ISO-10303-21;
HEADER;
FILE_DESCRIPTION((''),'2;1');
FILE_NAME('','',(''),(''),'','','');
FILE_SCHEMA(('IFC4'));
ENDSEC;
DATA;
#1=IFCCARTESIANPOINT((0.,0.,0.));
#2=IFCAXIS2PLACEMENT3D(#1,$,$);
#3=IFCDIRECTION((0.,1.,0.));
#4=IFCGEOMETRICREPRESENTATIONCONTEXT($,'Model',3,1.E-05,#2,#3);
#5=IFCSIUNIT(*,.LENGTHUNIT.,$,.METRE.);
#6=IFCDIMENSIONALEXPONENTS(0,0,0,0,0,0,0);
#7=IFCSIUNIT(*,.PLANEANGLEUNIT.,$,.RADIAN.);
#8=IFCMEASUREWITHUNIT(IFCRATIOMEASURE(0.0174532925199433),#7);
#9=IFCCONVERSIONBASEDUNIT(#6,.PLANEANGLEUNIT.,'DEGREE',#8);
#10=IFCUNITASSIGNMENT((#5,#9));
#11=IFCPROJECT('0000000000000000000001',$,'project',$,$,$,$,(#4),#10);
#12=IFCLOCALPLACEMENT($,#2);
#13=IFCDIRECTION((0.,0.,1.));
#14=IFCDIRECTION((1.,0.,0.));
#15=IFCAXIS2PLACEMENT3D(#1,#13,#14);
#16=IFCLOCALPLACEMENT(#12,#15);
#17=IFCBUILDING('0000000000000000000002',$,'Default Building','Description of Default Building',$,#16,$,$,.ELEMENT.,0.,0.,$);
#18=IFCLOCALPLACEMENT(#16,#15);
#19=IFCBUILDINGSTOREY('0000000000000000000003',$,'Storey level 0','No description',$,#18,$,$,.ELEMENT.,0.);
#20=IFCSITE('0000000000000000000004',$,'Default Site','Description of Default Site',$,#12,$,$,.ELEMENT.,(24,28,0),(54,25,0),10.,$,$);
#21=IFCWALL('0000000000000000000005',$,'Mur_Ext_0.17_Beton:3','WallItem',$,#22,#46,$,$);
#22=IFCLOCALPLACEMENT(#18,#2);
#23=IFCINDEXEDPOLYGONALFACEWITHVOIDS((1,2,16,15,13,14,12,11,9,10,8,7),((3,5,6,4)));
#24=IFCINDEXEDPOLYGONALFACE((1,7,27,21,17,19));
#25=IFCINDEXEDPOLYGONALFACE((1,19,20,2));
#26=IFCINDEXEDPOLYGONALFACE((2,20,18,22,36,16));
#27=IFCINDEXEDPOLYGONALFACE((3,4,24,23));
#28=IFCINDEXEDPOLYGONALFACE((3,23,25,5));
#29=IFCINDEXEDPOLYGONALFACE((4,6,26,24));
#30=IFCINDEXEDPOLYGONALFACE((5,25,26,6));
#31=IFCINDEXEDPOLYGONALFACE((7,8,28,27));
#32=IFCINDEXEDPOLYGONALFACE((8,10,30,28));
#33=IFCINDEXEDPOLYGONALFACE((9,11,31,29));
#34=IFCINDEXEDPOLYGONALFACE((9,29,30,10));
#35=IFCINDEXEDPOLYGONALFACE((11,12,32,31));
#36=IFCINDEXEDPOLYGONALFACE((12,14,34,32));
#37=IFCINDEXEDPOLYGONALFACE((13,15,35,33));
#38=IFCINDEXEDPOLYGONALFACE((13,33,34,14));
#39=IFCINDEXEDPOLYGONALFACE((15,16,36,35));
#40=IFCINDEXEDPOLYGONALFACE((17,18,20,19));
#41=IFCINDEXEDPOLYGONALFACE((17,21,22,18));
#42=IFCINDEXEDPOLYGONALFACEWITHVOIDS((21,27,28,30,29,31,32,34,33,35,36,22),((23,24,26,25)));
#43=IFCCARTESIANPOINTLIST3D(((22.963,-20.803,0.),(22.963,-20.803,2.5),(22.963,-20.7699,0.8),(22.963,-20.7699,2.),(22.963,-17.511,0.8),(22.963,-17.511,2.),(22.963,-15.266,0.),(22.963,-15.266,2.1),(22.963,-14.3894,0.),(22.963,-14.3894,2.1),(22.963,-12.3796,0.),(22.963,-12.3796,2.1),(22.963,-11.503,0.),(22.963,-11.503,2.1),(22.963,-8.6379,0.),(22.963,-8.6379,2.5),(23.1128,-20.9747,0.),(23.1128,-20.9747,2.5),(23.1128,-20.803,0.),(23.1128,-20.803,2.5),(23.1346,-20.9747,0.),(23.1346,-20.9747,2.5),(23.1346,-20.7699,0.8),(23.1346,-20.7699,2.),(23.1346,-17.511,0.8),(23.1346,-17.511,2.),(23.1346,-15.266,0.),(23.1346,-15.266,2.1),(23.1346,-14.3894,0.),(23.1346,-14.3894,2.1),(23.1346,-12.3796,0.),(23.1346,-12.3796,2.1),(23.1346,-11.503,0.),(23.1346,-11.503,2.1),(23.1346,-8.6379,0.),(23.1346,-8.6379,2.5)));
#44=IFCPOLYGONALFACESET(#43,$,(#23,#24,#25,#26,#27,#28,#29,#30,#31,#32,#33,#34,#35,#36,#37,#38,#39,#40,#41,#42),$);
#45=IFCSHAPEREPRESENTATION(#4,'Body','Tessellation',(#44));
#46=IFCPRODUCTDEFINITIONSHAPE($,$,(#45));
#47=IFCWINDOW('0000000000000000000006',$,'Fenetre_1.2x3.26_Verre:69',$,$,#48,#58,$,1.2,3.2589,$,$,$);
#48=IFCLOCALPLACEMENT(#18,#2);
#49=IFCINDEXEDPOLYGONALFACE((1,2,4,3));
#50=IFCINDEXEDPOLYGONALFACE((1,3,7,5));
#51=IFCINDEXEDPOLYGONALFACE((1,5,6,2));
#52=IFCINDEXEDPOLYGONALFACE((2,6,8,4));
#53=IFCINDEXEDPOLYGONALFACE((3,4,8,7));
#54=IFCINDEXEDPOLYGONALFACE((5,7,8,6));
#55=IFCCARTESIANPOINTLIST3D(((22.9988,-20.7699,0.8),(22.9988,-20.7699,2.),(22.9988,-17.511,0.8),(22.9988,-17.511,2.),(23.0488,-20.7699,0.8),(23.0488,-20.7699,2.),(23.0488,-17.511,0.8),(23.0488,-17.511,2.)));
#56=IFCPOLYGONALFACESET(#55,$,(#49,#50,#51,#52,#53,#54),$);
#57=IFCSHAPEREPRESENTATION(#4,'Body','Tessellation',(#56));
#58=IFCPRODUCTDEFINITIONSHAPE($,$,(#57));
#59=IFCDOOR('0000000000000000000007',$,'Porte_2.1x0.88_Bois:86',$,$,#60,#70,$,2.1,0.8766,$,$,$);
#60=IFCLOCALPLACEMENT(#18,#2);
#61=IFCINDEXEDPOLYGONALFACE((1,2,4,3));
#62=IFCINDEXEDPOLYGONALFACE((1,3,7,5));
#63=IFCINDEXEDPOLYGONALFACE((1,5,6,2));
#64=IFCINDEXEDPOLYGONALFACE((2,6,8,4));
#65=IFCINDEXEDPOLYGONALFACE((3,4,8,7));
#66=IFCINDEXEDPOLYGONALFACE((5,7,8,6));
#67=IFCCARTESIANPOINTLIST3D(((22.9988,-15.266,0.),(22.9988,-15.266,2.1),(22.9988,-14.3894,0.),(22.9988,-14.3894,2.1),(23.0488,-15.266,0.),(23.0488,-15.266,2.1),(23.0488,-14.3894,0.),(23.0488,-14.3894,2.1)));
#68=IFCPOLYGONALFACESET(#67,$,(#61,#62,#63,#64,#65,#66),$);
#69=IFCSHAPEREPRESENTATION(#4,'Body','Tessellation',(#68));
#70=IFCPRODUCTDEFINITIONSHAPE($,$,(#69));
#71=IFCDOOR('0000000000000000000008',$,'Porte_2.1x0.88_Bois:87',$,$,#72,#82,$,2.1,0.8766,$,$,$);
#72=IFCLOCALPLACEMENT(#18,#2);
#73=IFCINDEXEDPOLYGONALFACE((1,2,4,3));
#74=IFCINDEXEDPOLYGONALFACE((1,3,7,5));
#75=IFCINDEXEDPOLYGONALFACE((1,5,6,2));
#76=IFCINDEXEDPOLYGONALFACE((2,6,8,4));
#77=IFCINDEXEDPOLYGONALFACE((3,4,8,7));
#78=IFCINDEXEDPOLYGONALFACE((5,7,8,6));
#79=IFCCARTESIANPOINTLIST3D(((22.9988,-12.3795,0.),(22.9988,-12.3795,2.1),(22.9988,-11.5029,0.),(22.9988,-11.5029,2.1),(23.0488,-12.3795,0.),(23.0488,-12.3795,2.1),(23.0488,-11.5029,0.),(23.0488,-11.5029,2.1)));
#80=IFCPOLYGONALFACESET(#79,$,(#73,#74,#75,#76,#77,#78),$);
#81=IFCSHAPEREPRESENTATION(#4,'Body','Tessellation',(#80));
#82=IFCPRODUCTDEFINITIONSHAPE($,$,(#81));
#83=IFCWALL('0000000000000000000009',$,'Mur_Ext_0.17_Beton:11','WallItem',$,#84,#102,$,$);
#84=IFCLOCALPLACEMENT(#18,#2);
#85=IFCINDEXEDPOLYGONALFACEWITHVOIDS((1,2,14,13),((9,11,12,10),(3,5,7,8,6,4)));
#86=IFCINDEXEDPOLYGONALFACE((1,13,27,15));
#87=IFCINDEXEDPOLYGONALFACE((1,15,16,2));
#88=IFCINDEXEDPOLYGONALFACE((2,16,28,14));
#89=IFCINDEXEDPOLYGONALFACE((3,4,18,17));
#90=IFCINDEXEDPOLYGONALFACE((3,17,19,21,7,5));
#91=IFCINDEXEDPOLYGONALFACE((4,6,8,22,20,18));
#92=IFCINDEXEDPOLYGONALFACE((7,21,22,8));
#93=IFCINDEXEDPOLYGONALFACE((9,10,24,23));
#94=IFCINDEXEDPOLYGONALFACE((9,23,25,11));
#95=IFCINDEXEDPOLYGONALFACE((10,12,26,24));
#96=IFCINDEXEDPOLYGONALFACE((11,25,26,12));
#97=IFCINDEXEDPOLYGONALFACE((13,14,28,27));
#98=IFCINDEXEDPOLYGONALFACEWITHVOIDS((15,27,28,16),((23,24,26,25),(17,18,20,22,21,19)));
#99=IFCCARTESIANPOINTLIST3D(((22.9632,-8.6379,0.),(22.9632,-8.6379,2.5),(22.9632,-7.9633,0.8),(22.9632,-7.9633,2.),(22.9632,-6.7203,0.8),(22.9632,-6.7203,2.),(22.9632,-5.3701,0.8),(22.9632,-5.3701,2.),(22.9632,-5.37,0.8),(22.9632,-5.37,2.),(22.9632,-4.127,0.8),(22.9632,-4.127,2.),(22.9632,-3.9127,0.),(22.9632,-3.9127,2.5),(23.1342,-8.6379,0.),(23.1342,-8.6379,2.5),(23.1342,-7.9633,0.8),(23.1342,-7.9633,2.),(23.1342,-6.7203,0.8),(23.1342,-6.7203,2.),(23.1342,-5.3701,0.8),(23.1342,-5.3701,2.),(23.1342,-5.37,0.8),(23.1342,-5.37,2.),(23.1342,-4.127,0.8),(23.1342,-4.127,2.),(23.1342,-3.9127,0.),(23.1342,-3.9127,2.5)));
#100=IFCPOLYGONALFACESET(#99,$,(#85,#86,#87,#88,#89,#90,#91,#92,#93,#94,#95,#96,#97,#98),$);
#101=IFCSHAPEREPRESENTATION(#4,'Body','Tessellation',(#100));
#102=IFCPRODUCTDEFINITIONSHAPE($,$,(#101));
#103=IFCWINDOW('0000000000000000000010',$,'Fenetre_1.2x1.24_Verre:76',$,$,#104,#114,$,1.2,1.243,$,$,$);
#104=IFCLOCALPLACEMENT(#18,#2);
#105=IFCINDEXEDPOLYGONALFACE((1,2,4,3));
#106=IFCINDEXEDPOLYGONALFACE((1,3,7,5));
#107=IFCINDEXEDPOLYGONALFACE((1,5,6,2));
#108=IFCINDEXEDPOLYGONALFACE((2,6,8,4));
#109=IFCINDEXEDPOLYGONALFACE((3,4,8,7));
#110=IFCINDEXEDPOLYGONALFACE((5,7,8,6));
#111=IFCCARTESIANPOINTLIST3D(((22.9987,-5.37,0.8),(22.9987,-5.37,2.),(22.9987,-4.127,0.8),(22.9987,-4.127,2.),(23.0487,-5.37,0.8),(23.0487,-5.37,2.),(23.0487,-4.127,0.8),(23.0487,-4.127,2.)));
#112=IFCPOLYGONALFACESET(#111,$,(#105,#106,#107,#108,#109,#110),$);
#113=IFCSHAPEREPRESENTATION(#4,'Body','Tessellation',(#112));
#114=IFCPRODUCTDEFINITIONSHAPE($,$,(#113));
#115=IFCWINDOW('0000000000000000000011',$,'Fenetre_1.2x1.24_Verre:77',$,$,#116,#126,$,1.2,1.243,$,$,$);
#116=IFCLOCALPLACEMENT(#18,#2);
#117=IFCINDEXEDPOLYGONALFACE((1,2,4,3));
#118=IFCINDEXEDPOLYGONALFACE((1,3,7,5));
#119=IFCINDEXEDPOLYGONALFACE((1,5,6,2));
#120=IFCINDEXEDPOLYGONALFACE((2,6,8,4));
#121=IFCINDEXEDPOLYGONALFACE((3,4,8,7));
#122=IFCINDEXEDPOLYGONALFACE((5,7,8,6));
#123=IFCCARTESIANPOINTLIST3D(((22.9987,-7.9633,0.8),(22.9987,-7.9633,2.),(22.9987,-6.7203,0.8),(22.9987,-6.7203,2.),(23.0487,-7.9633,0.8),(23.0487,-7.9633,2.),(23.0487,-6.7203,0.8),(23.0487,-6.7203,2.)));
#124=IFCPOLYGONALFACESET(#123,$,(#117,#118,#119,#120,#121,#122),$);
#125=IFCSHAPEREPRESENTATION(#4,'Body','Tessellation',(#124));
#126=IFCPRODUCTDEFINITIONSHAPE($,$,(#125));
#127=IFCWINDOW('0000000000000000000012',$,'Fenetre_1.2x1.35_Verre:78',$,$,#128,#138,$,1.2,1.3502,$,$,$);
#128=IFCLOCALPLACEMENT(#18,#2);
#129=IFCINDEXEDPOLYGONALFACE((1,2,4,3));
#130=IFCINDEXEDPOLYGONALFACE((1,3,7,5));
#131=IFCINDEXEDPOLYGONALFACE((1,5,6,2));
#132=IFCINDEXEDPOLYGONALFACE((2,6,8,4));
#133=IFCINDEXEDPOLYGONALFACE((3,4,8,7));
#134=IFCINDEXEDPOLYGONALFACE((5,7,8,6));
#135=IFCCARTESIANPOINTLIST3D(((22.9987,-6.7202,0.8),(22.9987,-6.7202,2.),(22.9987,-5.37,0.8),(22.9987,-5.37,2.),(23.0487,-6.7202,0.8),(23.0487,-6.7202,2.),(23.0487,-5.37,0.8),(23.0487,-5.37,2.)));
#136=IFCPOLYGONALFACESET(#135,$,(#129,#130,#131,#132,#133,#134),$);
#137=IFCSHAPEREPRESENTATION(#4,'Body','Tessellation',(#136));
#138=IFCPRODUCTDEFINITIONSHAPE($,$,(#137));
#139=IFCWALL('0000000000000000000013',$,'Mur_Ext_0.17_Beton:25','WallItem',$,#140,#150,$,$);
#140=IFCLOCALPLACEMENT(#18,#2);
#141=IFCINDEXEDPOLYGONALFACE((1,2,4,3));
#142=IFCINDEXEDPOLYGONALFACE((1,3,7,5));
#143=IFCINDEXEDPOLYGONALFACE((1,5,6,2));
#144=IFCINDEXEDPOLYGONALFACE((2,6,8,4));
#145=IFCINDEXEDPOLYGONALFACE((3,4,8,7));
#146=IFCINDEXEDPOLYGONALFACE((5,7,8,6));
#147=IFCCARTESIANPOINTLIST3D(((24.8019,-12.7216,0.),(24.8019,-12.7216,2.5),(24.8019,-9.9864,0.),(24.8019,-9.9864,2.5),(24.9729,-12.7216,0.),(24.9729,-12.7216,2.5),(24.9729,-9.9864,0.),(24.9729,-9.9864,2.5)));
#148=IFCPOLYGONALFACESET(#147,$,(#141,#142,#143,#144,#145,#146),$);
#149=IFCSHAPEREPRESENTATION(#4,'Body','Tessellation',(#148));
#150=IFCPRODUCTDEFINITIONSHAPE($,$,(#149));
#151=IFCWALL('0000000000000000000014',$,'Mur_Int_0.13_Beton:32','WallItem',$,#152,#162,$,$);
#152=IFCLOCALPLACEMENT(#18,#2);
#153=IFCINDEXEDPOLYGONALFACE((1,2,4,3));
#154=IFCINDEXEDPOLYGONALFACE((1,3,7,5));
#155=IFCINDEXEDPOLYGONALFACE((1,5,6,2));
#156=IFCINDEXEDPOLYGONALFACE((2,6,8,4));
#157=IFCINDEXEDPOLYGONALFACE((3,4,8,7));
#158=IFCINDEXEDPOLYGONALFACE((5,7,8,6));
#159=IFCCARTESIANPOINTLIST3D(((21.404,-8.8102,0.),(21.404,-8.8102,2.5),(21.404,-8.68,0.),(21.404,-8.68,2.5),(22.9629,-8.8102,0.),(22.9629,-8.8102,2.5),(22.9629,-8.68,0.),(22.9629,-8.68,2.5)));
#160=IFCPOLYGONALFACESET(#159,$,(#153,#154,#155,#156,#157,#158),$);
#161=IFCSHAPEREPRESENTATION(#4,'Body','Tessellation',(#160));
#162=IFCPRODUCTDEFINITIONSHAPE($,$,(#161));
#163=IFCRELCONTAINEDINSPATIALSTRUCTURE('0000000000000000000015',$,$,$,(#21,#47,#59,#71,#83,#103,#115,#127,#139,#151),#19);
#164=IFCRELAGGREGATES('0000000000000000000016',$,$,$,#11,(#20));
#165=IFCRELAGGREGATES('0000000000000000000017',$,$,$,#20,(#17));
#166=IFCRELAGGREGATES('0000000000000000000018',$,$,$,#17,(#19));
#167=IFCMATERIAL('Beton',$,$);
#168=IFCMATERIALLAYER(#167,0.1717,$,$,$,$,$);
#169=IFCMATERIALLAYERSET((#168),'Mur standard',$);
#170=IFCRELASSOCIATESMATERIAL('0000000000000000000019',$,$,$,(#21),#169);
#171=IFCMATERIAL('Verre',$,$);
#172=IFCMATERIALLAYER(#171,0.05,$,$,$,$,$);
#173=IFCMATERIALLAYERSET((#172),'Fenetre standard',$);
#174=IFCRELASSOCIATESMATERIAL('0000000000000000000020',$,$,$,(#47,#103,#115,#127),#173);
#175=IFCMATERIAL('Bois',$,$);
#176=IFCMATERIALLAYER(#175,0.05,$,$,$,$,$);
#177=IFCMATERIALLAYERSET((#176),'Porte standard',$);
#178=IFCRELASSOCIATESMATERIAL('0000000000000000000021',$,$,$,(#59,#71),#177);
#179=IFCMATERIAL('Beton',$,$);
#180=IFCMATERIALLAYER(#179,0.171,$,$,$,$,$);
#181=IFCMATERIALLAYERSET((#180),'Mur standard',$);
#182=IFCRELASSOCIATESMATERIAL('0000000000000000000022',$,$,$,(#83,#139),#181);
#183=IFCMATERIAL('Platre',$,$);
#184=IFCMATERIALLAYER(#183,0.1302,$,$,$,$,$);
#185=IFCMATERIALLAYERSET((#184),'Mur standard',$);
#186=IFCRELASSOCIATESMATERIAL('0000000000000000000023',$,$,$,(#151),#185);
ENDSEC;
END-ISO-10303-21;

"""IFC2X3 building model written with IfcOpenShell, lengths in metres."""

from ifc_helpers import new_model, entity, si_unit, converted_unit, direction, frame, origin, origin_with_axes, place, context, project, spatial, polyline, outline, extrude, material, layer, layer_set, layer_usage, element, fill, save


model = new_model("IFC2X3")

# Units and contexts
model_context = context("Model", 3, precision=1e-05, world=origin(), true_north=direction((0.0, 1.0, 0.0)))
ifc_project = project(units=[si_unit("LENGTHUNIT", "METRE"), converted_unit("PLANEANGLEUNIT", "DEGREE", entity("IfcRatioMeasure", 0.0174532925199433), si_unit("PLANEANGLEUNIT", "RADIAN"), dimensions=[0, 0, 0, 0, 0, 0, 0])], contexts=[model_context])

# Site, building, storey
site_placement = place(None, origin())
site = spatial("IfcSite", under=ifc_project, at=site_placement, Name="Default Site", Description="Description of Default Site", CompositionType="ELEMENT", RefLatitude=(24, 28, 0), RefLongitude=(54, 25, 0), RefElevation=10.0)
building_placement = place(site_placement, origin_with_axes())
building = spatial("IfcBuilding", under=site, at=building_placement, Name="Default Building", Description="Description of Default Building", CompositionType="ELEMENT", ElevationOfRefHeight=0.0, ElevationOfTerrain=0.0)
storey_placement = place(building_placement, origin_with_axes())
storey = spatial("IfcBuildingStorey", under=building, at=storey_placement, Name="Storey level 0", Description="No description", CompositionType="ELEMENT", Elevation=0.0)

# Wall, openings, window, doors
ifc_material_1 = material(Name="Beton")
ifc_layer_1 = layer(ifc_material_1, 0.1717)
ifc_layer_set_1 = layer_set([ifc_layer_1], Name="Mur standard")
ifc_layer_usage_1 = layer_usage(ifc_layer_set_1, "AXIS2", "NEGATIVE", 0.1717)
wall_1_placement = place(storey_placement, frame((23.0488, -8.6379, 0.0), z_axis=(0.0, 0.0, 1.0), x_axis=(0.0, -1.0, 0.0)))
wall_1 = element("IfcWall", 1, at=wall_1_placement, inside=storey, material=ifc_layer_usage_1, Name="Mur_Ext_0.17_Beton:3", Description="WallItem", context=model_context, shape_type="SweptSolid", body=[
    extrude(outline(polyline([(12.3368, 0.0858), (12.3368, 0.064), (12.1651, 0.064), (12.1651, -0.0858), (0.0, -0.0858), (0.0, 0.0858), (12.3368, 0.0858)])), origin(), (0.0, 0.0, 1.0), 2.5),
])
opening_1_placement = place(storey_placement, frame((22.9629, -17.511, 0.8), z_axis=(0.0, 0.0, 1.0), x_axis=(0.0, -1.0, 0.0)))
opening_1 = element("IfcOpeningElement", 2, at=opening_1_placement, cuts=wall_1, context=model_context, shape_type="SweptSolid", body=[
    extrude(outline(polyline([(0.0, -0.05), (3.2589, -0.05), (3.2589, 0.2217), (0.0, 0.2217), (0.0, -0.05)])), origin(), (0.0, 0.0, 1.0), 1.2),
])
opening_2_placement = place(storey_placement, frame((23.1346, -14.3894, 0.0), z_axis=(0.0, 0.0, 1.0), x_axis=(0.0, -1.0, 0.0)))
opening_2 = element("IfcOpeningElement", 3, at=opening_2_placement, cuts=wall_1, context=model_context, shape_type="SweptSolid", body=[
    extrude(outline(polyline([(0.0, -0.2217), (0.8766, -0.2217), (0.8766, 0.05), (0.0, 0.05), (0.0, -0.2217)])), origin(), (0.0, 0.0, 1.0), 2.1),
])
opening_3_placement = place(storey_placement, frame((23.1346, -11.503, 0.0), z_axis=(0.0, 0.0, 1.0), x_axis=(0.0, -1.0, 0.0)))
opening_3 = element("IfcOpeningElement", 4, at=opening_3_placement, cuts=wall_1, context=model_context, shape_type="SweptSolid", body=[
    extrude(outline(polyline([(0.0, -0.2217), (0.8766, -0.2217), (0.8766, 0.05), (0.0, 0.05), (0.0, -0.2217)])), origin(), (0.0, 0.0, 1.0), 2.1),
])
ifc_material_2 = material(Name="Verre")
ifc_layer_2 = layer(ifc_material_2, 0.05)
ifc_layer_set_2 = layer_set([ifc_layer_2], Name="Fenetre standard")
ifc_layer_usage_2 = layer_usage(ifc_layer_set_2, "AXIS2", "NEGATIVE", 0.05)
window_1_placement = place(wall_1_placement, frame((8.8731, 0.0, 0.8), z_axis=(0.0, 0.0, 1.0), x_axis=(1.0, 0.0, 0.0)))
window_1 = element("IfcWindow", 5, at=window_1_placement, inside=storey, material=ifc_layer_usage_2, Name="Fenetre_1.2x3.26_Verre:69", OverallHeight=1.2, OverallWidth=3.2589, context=model_context, shape_type="SweptSolid", body=[
    extrude(outline(polyline([(0.0, 0.0), (3.2589, 0.0), (3.2589, -0.05), (0.0, -0.05), (0.0, 0.0)])), origin(), (0.0, 0.0, 1.0), 1.2),
])
fill(opening_1, window_1)
ifc_material_3 = material(Name="Bois")
ifc_layer_3 = layer(ifc_material_3, 0.05)
ifc_layer_set_3 = layer_set([ifc_layer_3], Name="Porte standard")
ifc_layer_usage_3 = layer_usage(ifc_layer_set_3, "AXIS2", "NEGATIVE", 0.05)
door_1_placement = place(wall_1_placement, frame((5.7515, 0.0, 0.0), z_axis=(0.0, 0.0, 1.0), x_axis=(1.0, 0.0, 0.0)))
door_1 = element("IfcDoor", 6, at=door_1_placement, inside=storey, material=ifc_layer_usage_3, Name="Porte_2.1x0.88_Bois:86", OverallHeight=2.1, OverallWidth=0.8766, context=model_context, shape_type="SweptSolid", body=[
    extrude(outline(polyline([(0.0, 0.0), (0.8766, 0.0), (0.8766, -0.05), (0.0, -0.05), (0.0, 0.0)])), origin(), (0.0, 0.0, 1.0), 2.1),
])
fill(opening_2, door_1)
door_2_placement = place(wall_1_placement, frame((2.865, 0.0, 0.0), z_axis=(0.0, 0.0, 1.0), x_axis=(1.0, 0.0, 0.0)))
door_2 = element("IfcDoor", 7, at=door_2_placement, inside=storey, material=ifc_layer_usage_3, Name="Porte_2.1x0.88_Bois:87", OverallHeight=2.1, OverallWidth=0.8766, context=model_context, shape_type="SweptSolid", body=[
    extrude(outline(polyline([(0.0, 0.0), (0.8766, 0.0), (0.8766, -0.05), (0.0, -0.05), (0.0, 0.0)])), origin(), (0.0, 0.0, 1.0), 2.1),
])
fill(opening_3, door_2)

# Wall, openings, windows
ifc_material_4 = material(Name="Beton")
ifc_layer_4 = layer(ifc_material_4, 0.171)
ifc_layer_set_4 = layer_set([ifc_layer_4], Name="Mur standard")
ifc_layer_usage_4 = layer_usage(ifc_layer_set_4, "AXIS2", "NEGATIVE", 0.171)
wall_2_placement = place(storey_placement, frame((23.0487, -3.9127, 0.0), z_axis=(0.0, 0.0, 1.0), x_axis=(0.0, -1.0, 0.0)))
wall_2 = element("IfcWall", 8, at=wall_2_placement, inside=storey, material=ifc_layer_usage_4, Name="Mur_Ext_0.17_Beton:11", Description="WallItem", context=model_context, shape_type="SweptSolid", body=[
    extrude(outline(polyline([(0.0, -0.0855), (4.7252, -0.0855), (4.7252, 0.0855), (0.0, 0.0855), (0.0, -0.0855)])), origin(), (0.0, 0.0, 1.0), 2.5),
])
opening_4_placement = place(storey_placement, frame((22.9631, -4.127, 0.8), z_axis=(0.0, 0.0, 1.0), x_axis=(0.0, -1.0, 0.0)))
opening_4 = element("IfcOpeningElement", 9, at=opening_4_placement, cuts=wall_2, context=model_context, shape_type="SweptSolid", body=[
    extrude(outline(polyline([(0.0, -0.05), (1.243, -0.05), (1.243, 0.221), (0.0, 0.221), (0.0, -0.05)])), origin(), (0.0, 0.0, 1.0), 1.2),
])
opening_5_placement = place(storey_placement, frame((22.9631, -6.7203, 0.8), z_axis=(0.0, 0.0, 1.0), x_axis=(0.0, -1.0, 0.0)))
opening_5 = element("IfcOpeningElement", 10, at=opening_5_placement, cuts=wall_2, context=model_context, shape_type="SweptSolid", body=[
    extrude(outline(polyline([(0.0, -0.05), (1.243, -0.05), (1.243, 0.221), (0.0, 0.221), (0.0, -0.05)])), origin(), (0.0, 0.0, 1.0), 1.2),
])
opening_6_placement = place(storey_placement, frame((22.9631, -5.3701, 0.8), z_axis=(0.0, 0.0, 1.0), x_axis=(0.0, -1.0, 0.0)))
opening_6 = element("IfcOpeningElement", 11, at=opening_6_placement, cuts=wall_2, context=model_context, shape_type="SweptSolid", body=[
    extrude(outline(polyline([(0.0, -0.05), (1.3502, -0.05), (1.3502, 0.221), (0.0, 0.221), (0.0, -0.05)])), origin(), (0.0, 0.0, 1.0), 1.2),
])
window_2_placement = place(wall_2_placement, frame((0.2143, 0.0, 0.8), z_axis=(0.0, 0.0, 1.0), x_axis=(1.0, 0.0, 0.0)))
window_2 = element("IfcWindow", 12, at=window_2_placement, inside=storey, material=ifc_layer_usage_2, Name="Fenetre_1.2x1.24_Verre:76", OverallHeight=1.2, OverallWidth=1.243, context=model_context, shape_type="SweptSolid", body=[
    extrude(outline(polyline([(0.0, 0.0), (1.243, 0.0), (1.243, -0.05), (0.0, -0.05), (0.0, 0.0)])), origin(), (0.0, 0.0, 1.0), 1.2),
])
fill(opening_4, window_2)
window_3_placement = place(wall_2_placement, frame((2.8076, 0.0, 0.8), z_axis=(0.0, 0.0, 1.0), x_axis=(1.0, 0.0, 0.0)))
window_3 = element("IfcWindow", 13, at=window_3_placement, inside=storey, material=ifc_layer_usage_2, Name="Fenetre_1.2x1.24_Verre:77", OverallHeight=1.2, OverallWidth=1.243, context=model_context, shape_type="SweptSolid", body=[
    extrude(outline(polyline([(0.0, 0.0), (1.243, 0.0), (1.243, -0.05), (0.0, -0.05), (0.0, 0.0)])), origin(), (0.0, 0.0, 1.0), 1.2),
])
fill(opening_5, window_3)
window_4_placement = place(wall_2_placement, frame((1.4573, 0.0, 0.8), z_axis=(0.0, 0.0, 1.0), x_axis=(1.0, 0.0, 0.0)))
window_4 = element("IfcWindow", 14, at=window_4_placement, inside=storey, material=ifc_layer_usage_2, Name="Fenetre_1.2x1.35_Verre:78", OverallHeight=1.2, OverallWidth=1.3502, context=model_context, shape_type="SweptSolid", body=[
    extrude(outline(polyline([(0.0, 0.0), (1.3502, 0.0), (1.3502, -0.05), (0.0, -0.05), (0.0, 0.0)])), origin(), (0.0, 0.0, 1.0), 1.2),
])
fill(opening_6, window_4)

# Wall
wall_3_placement = place(storey_placement, frame((24.8874, -9.9864, 0.0), z_axis=(0.0, 0.0, 1.0), x_axis=(0.0, -1.0, 0.0)))
element("IfcWall", 15, at=wall_3_placement, inside=storey, material=ifc_layer_usage_4, Name="Mur_Ext_0.17_Beton:25", Description="WallItem", context=model_context, shape_type="SweptSolid", body=[
    extrude(outline(polyline([(0.0, -0.0855), (2.7352, -0.0855), (2.7352, 0.0855), (0.0, 0.0855), (0.0, -0.0855)])), origin(), (0.0, 0.0, 1.0), 2.5),
])

# Wall
ifc_material_5 = material(Name="Platre")
ifc_layer_5 = layer(ifc_material_5, 0.1302)
ifc_layer_set_5 = layer_set([ifc_layer_5], Name="Mur standard")
ifc_layer_usage_5 = layer_usage(ifc_layer_set_5, "AXIS2", "NEGATIVE", 0.1302)
wall_4_placement = place(storey_placement, frame((21.404, -8.7451, 0.0), z_axis=(0.0, 0.0, 1.0), x_axis=(1.0, 0.0, 0.0)))
element("IfcWall", 16, at=wall_4_placement, inside=storey, material=ifc_layer_usage_5, Name="Mur_Int_0.13_Beton:32", Description="WallItem", context=model_context, shape_type="SweptSolid", body=[
    extrude(outline(polyline([(0.0, 0.0651), (0.0, -0.0651), (1.5589, -0.0651), (1.5589, 0.0651), (0.0, 0.0651)])), origin(), (0.0, 0.0, 1.0), 2.5),
])

save(model, "model.ifc")
